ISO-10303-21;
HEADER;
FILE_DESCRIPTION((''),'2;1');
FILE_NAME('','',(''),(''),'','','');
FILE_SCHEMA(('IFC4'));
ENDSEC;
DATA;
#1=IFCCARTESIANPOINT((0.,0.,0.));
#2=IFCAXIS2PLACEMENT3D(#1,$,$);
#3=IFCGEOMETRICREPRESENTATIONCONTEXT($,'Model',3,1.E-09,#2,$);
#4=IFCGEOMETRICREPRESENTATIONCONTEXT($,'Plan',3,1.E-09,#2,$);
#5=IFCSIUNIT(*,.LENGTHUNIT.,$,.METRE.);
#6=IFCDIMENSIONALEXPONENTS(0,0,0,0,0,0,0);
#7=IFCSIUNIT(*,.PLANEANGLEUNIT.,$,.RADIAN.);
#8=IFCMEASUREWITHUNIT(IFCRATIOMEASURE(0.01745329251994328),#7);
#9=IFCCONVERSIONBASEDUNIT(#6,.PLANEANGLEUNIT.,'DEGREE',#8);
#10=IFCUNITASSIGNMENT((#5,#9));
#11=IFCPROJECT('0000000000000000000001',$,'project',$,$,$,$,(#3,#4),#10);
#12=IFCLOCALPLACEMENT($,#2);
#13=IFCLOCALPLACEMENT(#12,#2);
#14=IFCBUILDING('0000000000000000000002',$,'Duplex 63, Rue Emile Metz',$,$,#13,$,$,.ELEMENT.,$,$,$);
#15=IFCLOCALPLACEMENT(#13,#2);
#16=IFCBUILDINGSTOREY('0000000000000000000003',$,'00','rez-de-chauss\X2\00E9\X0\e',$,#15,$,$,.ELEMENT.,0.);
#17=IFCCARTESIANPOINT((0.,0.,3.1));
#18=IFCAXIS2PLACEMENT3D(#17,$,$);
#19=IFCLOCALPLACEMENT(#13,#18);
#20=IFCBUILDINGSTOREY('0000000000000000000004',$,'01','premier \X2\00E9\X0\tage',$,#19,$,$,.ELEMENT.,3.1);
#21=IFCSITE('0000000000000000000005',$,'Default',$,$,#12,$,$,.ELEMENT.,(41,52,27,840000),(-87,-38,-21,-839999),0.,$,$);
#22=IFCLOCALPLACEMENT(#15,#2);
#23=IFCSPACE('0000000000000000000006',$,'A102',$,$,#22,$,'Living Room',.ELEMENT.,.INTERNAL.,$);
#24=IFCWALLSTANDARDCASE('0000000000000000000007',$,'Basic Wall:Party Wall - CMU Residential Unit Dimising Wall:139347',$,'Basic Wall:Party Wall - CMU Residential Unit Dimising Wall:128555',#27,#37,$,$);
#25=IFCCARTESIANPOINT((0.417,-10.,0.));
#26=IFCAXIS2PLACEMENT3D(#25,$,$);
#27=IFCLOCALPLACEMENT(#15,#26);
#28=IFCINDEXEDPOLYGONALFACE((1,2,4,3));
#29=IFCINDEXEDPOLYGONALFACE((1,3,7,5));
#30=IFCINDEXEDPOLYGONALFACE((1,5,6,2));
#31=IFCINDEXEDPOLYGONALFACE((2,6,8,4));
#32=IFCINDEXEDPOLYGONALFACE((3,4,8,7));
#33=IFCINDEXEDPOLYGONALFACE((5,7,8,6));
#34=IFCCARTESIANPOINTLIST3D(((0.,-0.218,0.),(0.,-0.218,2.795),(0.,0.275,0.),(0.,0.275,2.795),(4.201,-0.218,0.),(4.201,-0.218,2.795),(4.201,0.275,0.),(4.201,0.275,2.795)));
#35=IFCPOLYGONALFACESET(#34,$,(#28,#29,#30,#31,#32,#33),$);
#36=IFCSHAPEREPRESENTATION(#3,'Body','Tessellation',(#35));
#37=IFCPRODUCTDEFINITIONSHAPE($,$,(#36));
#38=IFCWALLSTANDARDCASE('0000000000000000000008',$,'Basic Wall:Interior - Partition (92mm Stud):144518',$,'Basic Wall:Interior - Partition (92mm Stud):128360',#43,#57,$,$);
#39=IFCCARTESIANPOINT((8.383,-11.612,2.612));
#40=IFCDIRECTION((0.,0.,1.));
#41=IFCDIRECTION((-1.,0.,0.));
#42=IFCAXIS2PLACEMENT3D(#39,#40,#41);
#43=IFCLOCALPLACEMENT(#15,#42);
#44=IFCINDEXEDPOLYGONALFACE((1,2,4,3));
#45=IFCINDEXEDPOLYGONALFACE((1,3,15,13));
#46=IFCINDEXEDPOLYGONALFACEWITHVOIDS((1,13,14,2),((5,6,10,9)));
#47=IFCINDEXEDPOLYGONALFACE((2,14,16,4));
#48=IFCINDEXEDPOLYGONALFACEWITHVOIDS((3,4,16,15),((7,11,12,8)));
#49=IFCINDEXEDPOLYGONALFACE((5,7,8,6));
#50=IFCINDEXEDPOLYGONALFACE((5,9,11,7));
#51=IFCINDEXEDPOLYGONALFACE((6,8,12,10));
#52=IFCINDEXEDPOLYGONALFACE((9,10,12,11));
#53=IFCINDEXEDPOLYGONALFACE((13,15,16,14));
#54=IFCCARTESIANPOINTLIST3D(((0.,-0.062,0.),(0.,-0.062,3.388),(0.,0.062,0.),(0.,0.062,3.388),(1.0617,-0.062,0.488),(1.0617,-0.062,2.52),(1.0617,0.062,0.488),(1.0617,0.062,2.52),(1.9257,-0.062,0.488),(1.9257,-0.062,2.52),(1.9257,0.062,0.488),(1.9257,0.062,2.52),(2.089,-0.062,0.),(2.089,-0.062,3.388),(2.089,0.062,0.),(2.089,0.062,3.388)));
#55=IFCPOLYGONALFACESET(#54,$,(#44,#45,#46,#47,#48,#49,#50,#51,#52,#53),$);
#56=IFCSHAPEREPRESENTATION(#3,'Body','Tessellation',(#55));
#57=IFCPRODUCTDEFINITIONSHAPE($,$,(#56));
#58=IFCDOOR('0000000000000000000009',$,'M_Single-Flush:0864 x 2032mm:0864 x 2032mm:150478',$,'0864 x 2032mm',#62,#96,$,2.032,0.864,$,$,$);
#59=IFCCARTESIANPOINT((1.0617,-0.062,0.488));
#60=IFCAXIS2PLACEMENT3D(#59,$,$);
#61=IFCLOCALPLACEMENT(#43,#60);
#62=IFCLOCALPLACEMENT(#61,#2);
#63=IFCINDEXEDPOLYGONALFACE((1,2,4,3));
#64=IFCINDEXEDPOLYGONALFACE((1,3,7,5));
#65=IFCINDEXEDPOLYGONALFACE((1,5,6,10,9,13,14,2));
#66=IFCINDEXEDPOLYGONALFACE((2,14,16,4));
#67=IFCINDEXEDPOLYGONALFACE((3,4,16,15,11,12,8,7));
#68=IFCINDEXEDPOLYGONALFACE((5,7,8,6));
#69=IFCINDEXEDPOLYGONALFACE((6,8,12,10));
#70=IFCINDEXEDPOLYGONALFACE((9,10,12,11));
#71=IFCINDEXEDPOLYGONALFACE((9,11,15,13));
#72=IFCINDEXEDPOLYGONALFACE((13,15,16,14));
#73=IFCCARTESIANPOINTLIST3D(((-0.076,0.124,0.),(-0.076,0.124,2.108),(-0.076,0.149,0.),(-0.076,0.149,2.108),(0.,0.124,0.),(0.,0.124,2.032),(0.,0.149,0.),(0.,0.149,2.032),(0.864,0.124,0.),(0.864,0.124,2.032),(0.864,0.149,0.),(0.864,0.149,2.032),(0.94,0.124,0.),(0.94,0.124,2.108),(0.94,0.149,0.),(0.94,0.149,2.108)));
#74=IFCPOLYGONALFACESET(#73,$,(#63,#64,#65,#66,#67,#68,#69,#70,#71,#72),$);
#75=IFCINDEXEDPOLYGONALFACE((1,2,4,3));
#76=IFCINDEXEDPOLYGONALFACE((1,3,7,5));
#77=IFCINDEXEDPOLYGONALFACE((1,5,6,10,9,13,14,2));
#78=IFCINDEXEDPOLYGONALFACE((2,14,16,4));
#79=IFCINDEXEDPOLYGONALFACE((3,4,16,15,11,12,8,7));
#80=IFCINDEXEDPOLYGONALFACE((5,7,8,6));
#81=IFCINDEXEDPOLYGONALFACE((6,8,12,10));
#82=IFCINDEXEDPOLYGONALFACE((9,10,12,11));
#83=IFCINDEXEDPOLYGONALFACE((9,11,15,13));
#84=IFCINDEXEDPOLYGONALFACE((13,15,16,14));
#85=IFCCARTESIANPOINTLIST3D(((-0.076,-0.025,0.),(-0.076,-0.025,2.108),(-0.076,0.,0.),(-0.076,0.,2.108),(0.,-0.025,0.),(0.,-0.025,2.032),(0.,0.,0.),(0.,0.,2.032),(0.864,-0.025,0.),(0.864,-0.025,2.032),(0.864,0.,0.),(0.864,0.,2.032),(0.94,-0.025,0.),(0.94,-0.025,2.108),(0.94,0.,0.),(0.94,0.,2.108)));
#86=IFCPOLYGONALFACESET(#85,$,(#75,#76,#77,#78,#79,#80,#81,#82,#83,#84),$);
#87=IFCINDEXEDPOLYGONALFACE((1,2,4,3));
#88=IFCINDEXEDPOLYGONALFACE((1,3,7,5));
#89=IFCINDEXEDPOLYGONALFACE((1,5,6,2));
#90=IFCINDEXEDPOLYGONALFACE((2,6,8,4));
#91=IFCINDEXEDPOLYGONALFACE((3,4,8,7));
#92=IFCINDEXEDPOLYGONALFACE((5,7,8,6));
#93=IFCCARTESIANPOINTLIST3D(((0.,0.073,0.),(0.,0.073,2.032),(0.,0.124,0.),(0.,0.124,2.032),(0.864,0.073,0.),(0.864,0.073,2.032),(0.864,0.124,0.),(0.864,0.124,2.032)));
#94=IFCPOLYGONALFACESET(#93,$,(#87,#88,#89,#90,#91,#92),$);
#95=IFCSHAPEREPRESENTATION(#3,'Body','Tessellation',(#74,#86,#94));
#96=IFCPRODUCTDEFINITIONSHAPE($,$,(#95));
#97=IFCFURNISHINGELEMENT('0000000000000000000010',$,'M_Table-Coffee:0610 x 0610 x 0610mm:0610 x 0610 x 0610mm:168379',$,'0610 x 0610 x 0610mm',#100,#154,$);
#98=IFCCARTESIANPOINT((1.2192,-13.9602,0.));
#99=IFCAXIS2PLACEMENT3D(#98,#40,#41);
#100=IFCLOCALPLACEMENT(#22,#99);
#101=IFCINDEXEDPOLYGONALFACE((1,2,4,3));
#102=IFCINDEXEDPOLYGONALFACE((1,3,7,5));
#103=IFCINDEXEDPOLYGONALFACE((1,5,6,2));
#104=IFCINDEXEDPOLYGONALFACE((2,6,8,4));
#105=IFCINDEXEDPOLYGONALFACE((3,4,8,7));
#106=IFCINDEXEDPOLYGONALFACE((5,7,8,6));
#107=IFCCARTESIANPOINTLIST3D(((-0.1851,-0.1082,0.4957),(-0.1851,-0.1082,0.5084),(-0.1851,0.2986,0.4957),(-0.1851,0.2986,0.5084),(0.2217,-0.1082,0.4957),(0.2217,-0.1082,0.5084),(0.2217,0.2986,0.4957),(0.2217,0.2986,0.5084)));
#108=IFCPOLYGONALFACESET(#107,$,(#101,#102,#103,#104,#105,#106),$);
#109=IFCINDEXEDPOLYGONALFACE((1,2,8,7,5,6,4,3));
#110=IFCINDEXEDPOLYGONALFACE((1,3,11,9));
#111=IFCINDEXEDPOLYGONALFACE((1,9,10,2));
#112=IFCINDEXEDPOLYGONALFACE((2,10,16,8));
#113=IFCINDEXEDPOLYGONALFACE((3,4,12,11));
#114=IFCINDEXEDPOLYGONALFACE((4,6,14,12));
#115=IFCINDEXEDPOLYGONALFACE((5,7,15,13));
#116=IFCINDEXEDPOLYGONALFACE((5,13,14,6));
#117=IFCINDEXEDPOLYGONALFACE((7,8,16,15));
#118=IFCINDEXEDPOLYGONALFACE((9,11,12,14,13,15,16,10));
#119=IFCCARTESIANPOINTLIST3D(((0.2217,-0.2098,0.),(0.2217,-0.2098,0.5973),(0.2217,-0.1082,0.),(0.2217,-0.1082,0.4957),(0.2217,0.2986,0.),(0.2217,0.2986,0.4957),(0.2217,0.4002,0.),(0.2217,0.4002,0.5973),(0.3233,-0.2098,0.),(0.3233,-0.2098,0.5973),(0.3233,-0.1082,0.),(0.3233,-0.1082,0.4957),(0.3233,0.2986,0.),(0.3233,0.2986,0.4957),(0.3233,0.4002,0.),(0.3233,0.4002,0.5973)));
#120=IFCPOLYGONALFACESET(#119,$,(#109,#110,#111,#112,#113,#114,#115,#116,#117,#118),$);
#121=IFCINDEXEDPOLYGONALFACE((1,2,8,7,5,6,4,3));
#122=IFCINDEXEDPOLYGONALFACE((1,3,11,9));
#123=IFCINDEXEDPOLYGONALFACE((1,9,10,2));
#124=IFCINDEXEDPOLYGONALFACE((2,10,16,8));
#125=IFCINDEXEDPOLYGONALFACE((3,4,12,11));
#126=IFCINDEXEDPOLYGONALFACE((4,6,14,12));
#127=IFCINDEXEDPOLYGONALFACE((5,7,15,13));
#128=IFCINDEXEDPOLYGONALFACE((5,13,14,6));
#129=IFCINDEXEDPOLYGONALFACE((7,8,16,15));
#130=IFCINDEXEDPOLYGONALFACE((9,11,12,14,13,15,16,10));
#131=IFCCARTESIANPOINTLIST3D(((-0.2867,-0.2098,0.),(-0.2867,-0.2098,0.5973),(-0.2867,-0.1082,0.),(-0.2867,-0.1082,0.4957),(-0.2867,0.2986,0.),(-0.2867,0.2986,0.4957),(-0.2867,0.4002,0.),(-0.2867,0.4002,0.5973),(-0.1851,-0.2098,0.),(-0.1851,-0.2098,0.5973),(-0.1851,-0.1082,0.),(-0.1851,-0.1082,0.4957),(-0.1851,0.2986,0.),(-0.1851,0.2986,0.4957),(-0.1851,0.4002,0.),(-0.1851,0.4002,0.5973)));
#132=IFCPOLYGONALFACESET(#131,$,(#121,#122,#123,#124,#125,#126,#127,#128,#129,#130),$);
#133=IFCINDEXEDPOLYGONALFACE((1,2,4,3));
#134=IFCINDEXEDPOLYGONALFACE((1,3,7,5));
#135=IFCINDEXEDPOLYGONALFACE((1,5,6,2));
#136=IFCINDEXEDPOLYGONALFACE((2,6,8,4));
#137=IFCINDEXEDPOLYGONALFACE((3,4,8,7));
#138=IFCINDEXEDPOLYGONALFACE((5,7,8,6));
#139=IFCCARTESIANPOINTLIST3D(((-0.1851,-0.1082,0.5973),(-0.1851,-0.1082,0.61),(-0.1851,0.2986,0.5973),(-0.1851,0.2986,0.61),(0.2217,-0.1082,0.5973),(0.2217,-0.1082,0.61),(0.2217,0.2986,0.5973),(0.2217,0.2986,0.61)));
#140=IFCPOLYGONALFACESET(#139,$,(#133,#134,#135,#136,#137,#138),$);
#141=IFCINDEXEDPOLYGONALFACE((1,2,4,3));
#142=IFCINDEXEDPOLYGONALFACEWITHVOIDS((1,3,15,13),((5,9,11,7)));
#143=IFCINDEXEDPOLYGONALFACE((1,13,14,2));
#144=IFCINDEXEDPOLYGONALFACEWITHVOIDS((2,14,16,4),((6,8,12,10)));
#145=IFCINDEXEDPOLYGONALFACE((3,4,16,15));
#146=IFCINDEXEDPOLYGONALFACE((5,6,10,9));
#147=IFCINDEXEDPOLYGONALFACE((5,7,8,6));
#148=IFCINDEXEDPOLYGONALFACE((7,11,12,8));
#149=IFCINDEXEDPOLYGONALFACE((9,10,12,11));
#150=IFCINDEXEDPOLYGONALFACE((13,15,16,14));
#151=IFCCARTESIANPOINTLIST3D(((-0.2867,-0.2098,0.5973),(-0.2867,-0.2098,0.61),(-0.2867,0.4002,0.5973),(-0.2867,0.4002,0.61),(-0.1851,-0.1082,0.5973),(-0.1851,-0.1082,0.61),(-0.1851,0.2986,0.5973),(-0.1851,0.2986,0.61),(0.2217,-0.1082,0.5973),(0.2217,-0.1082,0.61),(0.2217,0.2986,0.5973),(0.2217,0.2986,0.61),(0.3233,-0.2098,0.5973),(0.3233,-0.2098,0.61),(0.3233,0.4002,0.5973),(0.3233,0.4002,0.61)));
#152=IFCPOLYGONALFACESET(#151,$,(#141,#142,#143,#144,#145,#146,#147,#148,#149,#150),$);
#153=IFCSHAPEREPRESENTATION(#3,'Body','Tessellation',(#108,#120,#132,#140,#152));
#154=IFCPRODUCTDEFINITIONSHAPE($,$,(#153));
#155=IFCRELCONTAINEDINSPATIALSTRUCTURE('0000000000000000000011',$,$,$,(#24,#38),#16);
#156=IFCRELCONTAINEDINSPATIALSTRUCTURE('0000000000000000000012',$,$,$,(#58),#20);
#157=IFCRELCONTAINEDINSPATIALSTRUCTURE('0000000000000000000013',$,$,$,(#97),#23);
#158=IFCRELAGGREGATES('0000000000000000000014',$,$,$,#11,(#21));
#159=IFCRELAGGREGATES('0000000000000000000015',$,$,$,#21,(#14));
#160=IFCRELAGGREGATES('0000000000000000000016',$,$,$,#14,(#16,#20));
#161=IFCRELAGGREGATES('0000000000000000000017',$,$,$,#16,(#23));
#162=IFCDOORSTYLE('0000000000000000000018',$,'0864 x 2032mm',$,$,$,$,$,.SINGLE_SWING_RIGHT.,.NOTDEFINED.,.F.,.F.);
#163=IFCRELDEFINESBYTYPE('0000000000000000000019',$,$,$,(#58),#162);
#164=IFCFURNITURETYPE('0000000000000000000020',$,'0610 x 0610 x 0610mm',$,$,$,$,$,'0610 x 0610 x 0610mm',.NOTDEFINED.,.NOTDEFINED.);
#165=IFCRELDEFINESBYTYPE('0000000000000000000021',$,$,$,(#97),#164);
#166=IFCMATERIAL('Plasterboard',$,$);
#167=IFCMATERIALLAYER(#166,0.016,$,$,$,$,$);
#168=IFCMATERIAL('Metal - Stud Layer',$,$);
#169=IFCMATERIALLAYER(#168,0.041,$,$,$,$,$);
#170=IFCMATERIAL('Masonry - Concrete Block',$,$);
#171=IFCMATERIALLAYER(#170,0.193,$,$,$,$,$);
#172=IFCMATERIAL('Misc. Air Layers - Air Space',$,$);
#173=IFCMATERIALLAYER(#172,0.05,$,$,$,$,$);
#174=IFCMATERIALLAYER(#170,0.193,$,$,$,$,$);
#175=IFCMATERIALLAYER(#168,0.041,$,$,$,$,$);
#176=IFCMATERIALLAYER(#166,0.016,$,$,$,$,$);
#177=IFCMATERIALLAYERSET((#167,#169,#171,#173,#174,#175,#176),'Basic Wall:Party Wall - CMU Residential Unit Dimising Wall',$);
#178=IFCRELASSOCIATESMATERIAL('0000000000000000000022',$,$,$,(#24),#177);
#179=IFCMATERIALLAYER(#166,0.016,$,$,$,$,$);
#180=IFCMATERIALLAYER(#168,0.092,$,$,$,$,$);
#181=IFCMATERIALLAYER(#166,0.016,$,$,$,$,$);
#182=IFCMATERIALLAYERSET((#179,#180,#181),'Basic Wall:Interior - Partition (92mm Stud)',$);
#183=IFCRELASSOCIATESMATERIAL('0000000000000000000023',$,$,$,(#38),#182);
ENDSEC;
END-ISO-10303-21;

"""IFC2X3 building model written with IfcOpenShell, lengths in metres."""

from ifc_helpers import new_model, entity, si_unit, converted_unit, frame, frame_2d, origin, origin_2d_with_axis, place, context, project, spatial, polyline, rectangle, outline, extrude, clip, bounded_halfspace, source, transform, mapped, material, layer, layer_set, layer_usage, type_object, type_shapes, element, fill, save


model = new_model("IFC2X3")

# Units and contexts
model_context = context("Model", 3, precision=1e-09, world=origin())
plan_context = context("Plan", 3, precision=1e-09, world=origin())
ifc_project = project(units=[si_unit("LENGTHUNIT", "METRE"), converted_unit("PLANEANGLEUNIT", "DEGREE", entity("IfcRatioMeasure", 0.01745329251994328), si_unit("PLANEANGLEUNIT", "RADIAN"), dimensions=[0, 0, 0, 0, 0, 0, 0])], contexts=[model_context, plan_context])

# Site, building, storey
site_placement = place(None, origin())
site = spatial("IfcSite", under=ifc_project, at=site_placement, Name="Default", CompositionType="ELEMENT", RefLatitude=(41, 52, 27, 840000), RefLongitude=(-87, -38, -21, -839999), RefElevation=0.0)
building_placement = place(site_placement, origin())
building = spatial("IfcBuilding", under=site, at=building_placement, Name="Duplex 63, Rue Emile Metz", CompositionType="ELEMENT")
storey_1_placement = place(building_placement, origin())
storey_1 = spatial("IfcBuildingStorey", under=building, at=storey_1_placement, Name="00", Description="rez-de-chaussée", CompositionType="ELEMENT", Elevation=0.0)

# Shared definitions
ifc_material_1 = material(Name="Misc. Air Layers - Air Space")
ifc_material_2 = material(Name="Masonry - Concrete Block")
ifc_material_3 = material(Name="Metal - Stud Layer")
ifc_material_4 = material(Name="Plasterboard")

# Wall
ifc_layer_1 = layer(ifc_material_4, 0.016)
ifc_layer_2 = layer(ifc_material_3, 0.041)
ifc_layer_3 = layer(ifc_material_2, 0.193)
ifc_layer_4 = layer(ifc_material_1, 0.05)
ifc_layer_5 = layer(ifc_material_2, 0.193)
ifc_layer_6 = layer(ifc_material_3, 0.041)
ifc_layer_7 = layer(ifc_material_4, 0.016)
ifc_layer_set_1 = layer_set([ifc_layer_1, ifc_layer_2, ifc_layer_3, ifc_layer_4, ifc_layer_5, ifc_layer_6, ifc_layer_7], Name="Basic Wall:Party Wall - CMU Residential Unit Dimising Wall")
ifc_layer_usage_1 = layer_usage(ifc_layer_set_1, "AXIS2", "NEGATIVE", 0.275)
wall_1_placement = place(storey_1_placement, frame((0.417, -10.0, 0.0)))
element("IfcWallStandardCase", 1, at=wall_1_placement, inside=storey_1, material=ifc_layer_usage_1, Name="Basic Wall:Party Wall - CMU Residential Unit Dimising Wall:139347", ObjectType="Basic Wall:Party Wall - CMU Residential Unit Dimising Wall:128555", context=model_context, shape_type="Clipping", body=[
    clip(clip(extrude(rectangle(XDim=4.201, YDim=0.55, at=frame_2d((2.1005, 0.0), x_axis=(-1.0, 0.0))), origin(), (0.0, 0.0, 1.0), 2.795), bounded_halfspace(frame((0.0, -0.218, 0.0), z_axis=(0.0, 1.0, 0.0), x_axis=(-1.0, 0.0, 0.0)), True, frame((0.0, -0.218, 0.0), z_axis=(0.0, 1.0, 0.0), x_axis=(-1.0, 0.0, 0.0)), polyline([(0.0, 0.0), (0.0, 2.795), (-4.201, 2.795), (-4.201, 0.0), (0.0, 0.0)]))), bounded_halfspace(frame((4.201, 0.275, 0.0), z_axis=(-1.0, 0.0, 0.0), x_axis=(0.0, -1.0, 0.0)), True, frame((4.201, 0.275, 0.0), z_axis=(-1.0, 0.0, 0.0), x_axis=(0.0, -1.0, 0.0)), polyline([(0.0, 0.0), (0.493, 0.0), (0.493, 2.795), (0.0, 2.795), (0.0, 0.0)]))),
])
ifc_layer_8 = layer(ifc_material_4, 0.016)
ifc_layer_9 = layer(ifc_material_3, 0.092)
ifc_layer_10 = layer(ifc_material_4, 0.016)
ifc_layer_set_2 = layer_set([ifc_layer_8, ifc_layer_9, ifc_layer_10], Name="Basic Wall:Interior - Partition (92mm Stud)")
ifc_layer_usage_2 = layer_usage(ifc_layer_set_2, "AXIS2", "NEGATIVE", 0.062)

# Wall, opening
wall_2_placement = place(storey_1_placement, frame((8.383, -11.612, 2.612), z_axis=(0.0, 0.0, 1.0), x_axis=(-1.0, 0.0, 0.0)))
wall_2 = element("IfcWallStandardCase", 2, at=wall_2_placement, inside=storey_1, material=ifc_layer_usage_2, Name="Basic Wall:Interior - Partition (92mm Stud):144518", ObjectType="Basic Wall:Interior - Partition (92mm Stud):128360", context=model_context, shape_type="SweptSolid", body=[
    extrude(rectangle(XDim=2.089, YDim=0.124, at=frame_2d((1.0445, 0.0), x_axis=(-1.0, 0.0))), origin(), (0.0, 0.0, 1.0), 3.388),
])
opening_1_placement = place(wall_2_placement, frame((1.0617, -0.062, 0.488)))
opening_1 = element("IfcOpeningElement", 3, at=opening_1_placement, cuts=wall_2, ObjectType="Opening", context=model_context, shape_type="SweptSolid", body=[
    extrude(rectangle(XDim=0.864, YDim=2.032, at=frame_2d((1.016, 0.432), x_axis=(0.0, 1.0))), frame((0.0, 0.0, 0.0), z_axis=(0.0, 1.0, 0.0), x_axis=(0.0, 0.0, 1.0)), (0.0, 0.0, 1.0), 0.124),
])

# Shared definitions
storey_2_placement = place(building_placement, frame((0.0, 0.0, 3.1)))
storey_2 = spatial("IfcBuildingStorey", under=building, at=storey_2_placement, Name="01", Description="premier étage", CompositionType="ELEMENT", Elevation=3.1)

# Door
door_style_1 = type_object("IfcDoorStyle", Name="0864 x 2032mm", ConstructionType="NOTDEFINED", OperationType="SINGLE_SWING_RIGHT", ParameterTakesPrecedence=False, Sizeable=False)
shared_shape_1 = source(origin(), model_context, "Body", "SweptSolid", [
    extrude(outline(polyline([(-0.508, -1.073), (0.508, -1.073), (0.508, 1.035), (0.432, 1.035), (0.432, -0.997), (-0.432, -0.997), (-0.432, 1.035), (-0.508, 1.035), (-0.508, -1.073)])), frame((0.432, 0.124, 1.035), z_axis=(0.0, 1.0, 0.0), x_axis=(1.0, 0.0, 0.0)), (0.0, 0.0, 1.0), 0.025),
    extrude(outline(polyline([(-1.073, -0.508), (1.035, -0.508), (1.035, -0.432), (-0.997, -0.432), (-0.997, 0.432), (1.035, 0.432), (1.035, 0.508), (-1.073, 0.508), (-1.073, -0.508)])), frame((0.432, -0.025, 1.035), z_axis=(0.0, 1.0, 0.0), x_axis=(0.0, 0.0, -1.0)), (0.0, 0.0, 1.0), 0.025),
    extrude(rectangle(XDim=0.051, YDim=0.864, at=origin_2d_with_axis()), frame((0.432, 0.0985, 0.0), z_axis=(0.0, 0.0, 1.0), x_axis=(0.0, 1.0, 0.0)), (0.0, 0.0, 1.0), 2.032),
])
type_shapes(door_style_1, [shared_shape_1])
door_1_placement = place(opening_1_placement, origin())
door_1 = element("IfcDoor", 4, at=door_1_placement, inside=storey_2, type_object=door_style_1, Name="M_Single-Flush:0864 x 2032mm:0864 x 2032mm:150478", ObjectType="0864 x 2032mm", OverallHeight=2.032, OverallWidth=0.864, context=model_context, shape_type="MappedRepresentation", body=[
    mapped(shared_shape_1, transform((0.0, 0.0, 0.0), scale=1.0)),
])
fill(opening_1, door_1)

# Shared definitions
space_1_placement = place(storey_1_placement, origin())
space_1 = spatial("IfcSpace", under=storey_1, at=space_1_placement, Name="A102", LongName="Living Room", CompositionType="ELEMENT", InteriorOrExteriorSpace="INTERNAL")

# Furnishing element
furniture_type_1 = type_object("IfcFurnitureType", Name="0610 x 0610 x 0610mm", ElementType="0610 x 0610 x 0610mm", AssemblyPlace="NOTDEFINED")
shared_shape_2 = source(origin(), model_context, "Body", "SweptSolid", [
    extrude(rectangle(XDim=0.4068, YDim=0.4068, at=origin_2d_with_axis()), frame((0.0183, 0.0952, 0.4957), z_axis=(0.0, 0.0, 1.0), x_axis=(-1.0, 0.0, 0.0)), (0.0, 0.0, 1.0), 0.0127),
    extrude(outline(polyline([(-0.2732, -0.305), (0.324, -0.305), (0.324, 0.305), (-0.2732, 0.305), (-0.2732, 0.2034), (0.2225, 0.2034), (0.2225, -0.2034), (-0.2732, -0.2034), (-0.2732, -0.305)])), frame((0.2217, 0.0952, 0.2732), z_axis=(1.0, 0.0, 0.0), x_axis=(0.0, 0.0, 1.0)), (0.0, 0.0, 1.0), 0.1016),
    extrude(outline(polyline([(-0.305, -0.3241), (0.305, -0.3241), (0.305, 0.2733), (0.2034, 0.2733), (0.2034, -0.2224), (-0.2034, -0.2224), (-0.2034, 0.2733), (-0.305, 0.2733), (-0.305, -0.3241)])), frame((-0.2867, 0.0952, 0.2733), z_axis=(1.0, 0.0, 0.0), x_axis=(0.0, -1.0, 0.0)), (0.0, 0.0, 1.0), 0.1016),
    extrude(rectangle(XDim=0.4068, YDim=0.4068, at=origin_2d_with_axis()), frame((0.0183, 0.0952, 0.5973), z_axis=(0.0, 0.0, 1.0), x_axis=(-1.0, 0.0, 0.0)), (0.0, 0.0, 1.0), 0.0127),
    extrude(outline(polyline([(-0.305, -0.305), (0.305, -0.305), (0.305, 0.305), (-0.305, 0.305), (-0.305, -0.305)]), holes=[polyline([(-0.2034, -0.2034), (-0.2034, 0.2034), (0.2034, 0.2034), (0.2034, -0.2034), (-0.2034, -0.2034)])]), frame((0.0183, 0.0952, 0.5973), z_axis=(0.0, 0.0, 1.0), x_axis=(-1.0, 0.0, 0.0)), (0.0, 0.0, 1.0), 0.0127),
])
type_shapes(furniture_type_1, [shared_shape_2])
for number, where, z_axis, x_axis, name in (
    (5, (1.2192, -13.9602, 0.0), (0.0, 0.0, 1.0), (-1.0, 0.0, 0.0), "M_Table-Coffee:0610 x 0610 x 0610mm:0610 x 0610 x 0610mm:168379"),
):
    element("IfcFurnishingElement", number, at=place(space_1_placement, frame(where, z_axis=z_axis, x_axis=x_axis)), inside=space_1, type_object=furniture_type_1, Name=name, ObjectType="0610 x 0610 x 0610mm", context=model_context, shape_type="MappedRepresentation", body=[
        mapped(shared_shape_2, transform((0.0, 0.0, 0.0), scale=1.0)),
    ])

save(model, "model.ifc")
